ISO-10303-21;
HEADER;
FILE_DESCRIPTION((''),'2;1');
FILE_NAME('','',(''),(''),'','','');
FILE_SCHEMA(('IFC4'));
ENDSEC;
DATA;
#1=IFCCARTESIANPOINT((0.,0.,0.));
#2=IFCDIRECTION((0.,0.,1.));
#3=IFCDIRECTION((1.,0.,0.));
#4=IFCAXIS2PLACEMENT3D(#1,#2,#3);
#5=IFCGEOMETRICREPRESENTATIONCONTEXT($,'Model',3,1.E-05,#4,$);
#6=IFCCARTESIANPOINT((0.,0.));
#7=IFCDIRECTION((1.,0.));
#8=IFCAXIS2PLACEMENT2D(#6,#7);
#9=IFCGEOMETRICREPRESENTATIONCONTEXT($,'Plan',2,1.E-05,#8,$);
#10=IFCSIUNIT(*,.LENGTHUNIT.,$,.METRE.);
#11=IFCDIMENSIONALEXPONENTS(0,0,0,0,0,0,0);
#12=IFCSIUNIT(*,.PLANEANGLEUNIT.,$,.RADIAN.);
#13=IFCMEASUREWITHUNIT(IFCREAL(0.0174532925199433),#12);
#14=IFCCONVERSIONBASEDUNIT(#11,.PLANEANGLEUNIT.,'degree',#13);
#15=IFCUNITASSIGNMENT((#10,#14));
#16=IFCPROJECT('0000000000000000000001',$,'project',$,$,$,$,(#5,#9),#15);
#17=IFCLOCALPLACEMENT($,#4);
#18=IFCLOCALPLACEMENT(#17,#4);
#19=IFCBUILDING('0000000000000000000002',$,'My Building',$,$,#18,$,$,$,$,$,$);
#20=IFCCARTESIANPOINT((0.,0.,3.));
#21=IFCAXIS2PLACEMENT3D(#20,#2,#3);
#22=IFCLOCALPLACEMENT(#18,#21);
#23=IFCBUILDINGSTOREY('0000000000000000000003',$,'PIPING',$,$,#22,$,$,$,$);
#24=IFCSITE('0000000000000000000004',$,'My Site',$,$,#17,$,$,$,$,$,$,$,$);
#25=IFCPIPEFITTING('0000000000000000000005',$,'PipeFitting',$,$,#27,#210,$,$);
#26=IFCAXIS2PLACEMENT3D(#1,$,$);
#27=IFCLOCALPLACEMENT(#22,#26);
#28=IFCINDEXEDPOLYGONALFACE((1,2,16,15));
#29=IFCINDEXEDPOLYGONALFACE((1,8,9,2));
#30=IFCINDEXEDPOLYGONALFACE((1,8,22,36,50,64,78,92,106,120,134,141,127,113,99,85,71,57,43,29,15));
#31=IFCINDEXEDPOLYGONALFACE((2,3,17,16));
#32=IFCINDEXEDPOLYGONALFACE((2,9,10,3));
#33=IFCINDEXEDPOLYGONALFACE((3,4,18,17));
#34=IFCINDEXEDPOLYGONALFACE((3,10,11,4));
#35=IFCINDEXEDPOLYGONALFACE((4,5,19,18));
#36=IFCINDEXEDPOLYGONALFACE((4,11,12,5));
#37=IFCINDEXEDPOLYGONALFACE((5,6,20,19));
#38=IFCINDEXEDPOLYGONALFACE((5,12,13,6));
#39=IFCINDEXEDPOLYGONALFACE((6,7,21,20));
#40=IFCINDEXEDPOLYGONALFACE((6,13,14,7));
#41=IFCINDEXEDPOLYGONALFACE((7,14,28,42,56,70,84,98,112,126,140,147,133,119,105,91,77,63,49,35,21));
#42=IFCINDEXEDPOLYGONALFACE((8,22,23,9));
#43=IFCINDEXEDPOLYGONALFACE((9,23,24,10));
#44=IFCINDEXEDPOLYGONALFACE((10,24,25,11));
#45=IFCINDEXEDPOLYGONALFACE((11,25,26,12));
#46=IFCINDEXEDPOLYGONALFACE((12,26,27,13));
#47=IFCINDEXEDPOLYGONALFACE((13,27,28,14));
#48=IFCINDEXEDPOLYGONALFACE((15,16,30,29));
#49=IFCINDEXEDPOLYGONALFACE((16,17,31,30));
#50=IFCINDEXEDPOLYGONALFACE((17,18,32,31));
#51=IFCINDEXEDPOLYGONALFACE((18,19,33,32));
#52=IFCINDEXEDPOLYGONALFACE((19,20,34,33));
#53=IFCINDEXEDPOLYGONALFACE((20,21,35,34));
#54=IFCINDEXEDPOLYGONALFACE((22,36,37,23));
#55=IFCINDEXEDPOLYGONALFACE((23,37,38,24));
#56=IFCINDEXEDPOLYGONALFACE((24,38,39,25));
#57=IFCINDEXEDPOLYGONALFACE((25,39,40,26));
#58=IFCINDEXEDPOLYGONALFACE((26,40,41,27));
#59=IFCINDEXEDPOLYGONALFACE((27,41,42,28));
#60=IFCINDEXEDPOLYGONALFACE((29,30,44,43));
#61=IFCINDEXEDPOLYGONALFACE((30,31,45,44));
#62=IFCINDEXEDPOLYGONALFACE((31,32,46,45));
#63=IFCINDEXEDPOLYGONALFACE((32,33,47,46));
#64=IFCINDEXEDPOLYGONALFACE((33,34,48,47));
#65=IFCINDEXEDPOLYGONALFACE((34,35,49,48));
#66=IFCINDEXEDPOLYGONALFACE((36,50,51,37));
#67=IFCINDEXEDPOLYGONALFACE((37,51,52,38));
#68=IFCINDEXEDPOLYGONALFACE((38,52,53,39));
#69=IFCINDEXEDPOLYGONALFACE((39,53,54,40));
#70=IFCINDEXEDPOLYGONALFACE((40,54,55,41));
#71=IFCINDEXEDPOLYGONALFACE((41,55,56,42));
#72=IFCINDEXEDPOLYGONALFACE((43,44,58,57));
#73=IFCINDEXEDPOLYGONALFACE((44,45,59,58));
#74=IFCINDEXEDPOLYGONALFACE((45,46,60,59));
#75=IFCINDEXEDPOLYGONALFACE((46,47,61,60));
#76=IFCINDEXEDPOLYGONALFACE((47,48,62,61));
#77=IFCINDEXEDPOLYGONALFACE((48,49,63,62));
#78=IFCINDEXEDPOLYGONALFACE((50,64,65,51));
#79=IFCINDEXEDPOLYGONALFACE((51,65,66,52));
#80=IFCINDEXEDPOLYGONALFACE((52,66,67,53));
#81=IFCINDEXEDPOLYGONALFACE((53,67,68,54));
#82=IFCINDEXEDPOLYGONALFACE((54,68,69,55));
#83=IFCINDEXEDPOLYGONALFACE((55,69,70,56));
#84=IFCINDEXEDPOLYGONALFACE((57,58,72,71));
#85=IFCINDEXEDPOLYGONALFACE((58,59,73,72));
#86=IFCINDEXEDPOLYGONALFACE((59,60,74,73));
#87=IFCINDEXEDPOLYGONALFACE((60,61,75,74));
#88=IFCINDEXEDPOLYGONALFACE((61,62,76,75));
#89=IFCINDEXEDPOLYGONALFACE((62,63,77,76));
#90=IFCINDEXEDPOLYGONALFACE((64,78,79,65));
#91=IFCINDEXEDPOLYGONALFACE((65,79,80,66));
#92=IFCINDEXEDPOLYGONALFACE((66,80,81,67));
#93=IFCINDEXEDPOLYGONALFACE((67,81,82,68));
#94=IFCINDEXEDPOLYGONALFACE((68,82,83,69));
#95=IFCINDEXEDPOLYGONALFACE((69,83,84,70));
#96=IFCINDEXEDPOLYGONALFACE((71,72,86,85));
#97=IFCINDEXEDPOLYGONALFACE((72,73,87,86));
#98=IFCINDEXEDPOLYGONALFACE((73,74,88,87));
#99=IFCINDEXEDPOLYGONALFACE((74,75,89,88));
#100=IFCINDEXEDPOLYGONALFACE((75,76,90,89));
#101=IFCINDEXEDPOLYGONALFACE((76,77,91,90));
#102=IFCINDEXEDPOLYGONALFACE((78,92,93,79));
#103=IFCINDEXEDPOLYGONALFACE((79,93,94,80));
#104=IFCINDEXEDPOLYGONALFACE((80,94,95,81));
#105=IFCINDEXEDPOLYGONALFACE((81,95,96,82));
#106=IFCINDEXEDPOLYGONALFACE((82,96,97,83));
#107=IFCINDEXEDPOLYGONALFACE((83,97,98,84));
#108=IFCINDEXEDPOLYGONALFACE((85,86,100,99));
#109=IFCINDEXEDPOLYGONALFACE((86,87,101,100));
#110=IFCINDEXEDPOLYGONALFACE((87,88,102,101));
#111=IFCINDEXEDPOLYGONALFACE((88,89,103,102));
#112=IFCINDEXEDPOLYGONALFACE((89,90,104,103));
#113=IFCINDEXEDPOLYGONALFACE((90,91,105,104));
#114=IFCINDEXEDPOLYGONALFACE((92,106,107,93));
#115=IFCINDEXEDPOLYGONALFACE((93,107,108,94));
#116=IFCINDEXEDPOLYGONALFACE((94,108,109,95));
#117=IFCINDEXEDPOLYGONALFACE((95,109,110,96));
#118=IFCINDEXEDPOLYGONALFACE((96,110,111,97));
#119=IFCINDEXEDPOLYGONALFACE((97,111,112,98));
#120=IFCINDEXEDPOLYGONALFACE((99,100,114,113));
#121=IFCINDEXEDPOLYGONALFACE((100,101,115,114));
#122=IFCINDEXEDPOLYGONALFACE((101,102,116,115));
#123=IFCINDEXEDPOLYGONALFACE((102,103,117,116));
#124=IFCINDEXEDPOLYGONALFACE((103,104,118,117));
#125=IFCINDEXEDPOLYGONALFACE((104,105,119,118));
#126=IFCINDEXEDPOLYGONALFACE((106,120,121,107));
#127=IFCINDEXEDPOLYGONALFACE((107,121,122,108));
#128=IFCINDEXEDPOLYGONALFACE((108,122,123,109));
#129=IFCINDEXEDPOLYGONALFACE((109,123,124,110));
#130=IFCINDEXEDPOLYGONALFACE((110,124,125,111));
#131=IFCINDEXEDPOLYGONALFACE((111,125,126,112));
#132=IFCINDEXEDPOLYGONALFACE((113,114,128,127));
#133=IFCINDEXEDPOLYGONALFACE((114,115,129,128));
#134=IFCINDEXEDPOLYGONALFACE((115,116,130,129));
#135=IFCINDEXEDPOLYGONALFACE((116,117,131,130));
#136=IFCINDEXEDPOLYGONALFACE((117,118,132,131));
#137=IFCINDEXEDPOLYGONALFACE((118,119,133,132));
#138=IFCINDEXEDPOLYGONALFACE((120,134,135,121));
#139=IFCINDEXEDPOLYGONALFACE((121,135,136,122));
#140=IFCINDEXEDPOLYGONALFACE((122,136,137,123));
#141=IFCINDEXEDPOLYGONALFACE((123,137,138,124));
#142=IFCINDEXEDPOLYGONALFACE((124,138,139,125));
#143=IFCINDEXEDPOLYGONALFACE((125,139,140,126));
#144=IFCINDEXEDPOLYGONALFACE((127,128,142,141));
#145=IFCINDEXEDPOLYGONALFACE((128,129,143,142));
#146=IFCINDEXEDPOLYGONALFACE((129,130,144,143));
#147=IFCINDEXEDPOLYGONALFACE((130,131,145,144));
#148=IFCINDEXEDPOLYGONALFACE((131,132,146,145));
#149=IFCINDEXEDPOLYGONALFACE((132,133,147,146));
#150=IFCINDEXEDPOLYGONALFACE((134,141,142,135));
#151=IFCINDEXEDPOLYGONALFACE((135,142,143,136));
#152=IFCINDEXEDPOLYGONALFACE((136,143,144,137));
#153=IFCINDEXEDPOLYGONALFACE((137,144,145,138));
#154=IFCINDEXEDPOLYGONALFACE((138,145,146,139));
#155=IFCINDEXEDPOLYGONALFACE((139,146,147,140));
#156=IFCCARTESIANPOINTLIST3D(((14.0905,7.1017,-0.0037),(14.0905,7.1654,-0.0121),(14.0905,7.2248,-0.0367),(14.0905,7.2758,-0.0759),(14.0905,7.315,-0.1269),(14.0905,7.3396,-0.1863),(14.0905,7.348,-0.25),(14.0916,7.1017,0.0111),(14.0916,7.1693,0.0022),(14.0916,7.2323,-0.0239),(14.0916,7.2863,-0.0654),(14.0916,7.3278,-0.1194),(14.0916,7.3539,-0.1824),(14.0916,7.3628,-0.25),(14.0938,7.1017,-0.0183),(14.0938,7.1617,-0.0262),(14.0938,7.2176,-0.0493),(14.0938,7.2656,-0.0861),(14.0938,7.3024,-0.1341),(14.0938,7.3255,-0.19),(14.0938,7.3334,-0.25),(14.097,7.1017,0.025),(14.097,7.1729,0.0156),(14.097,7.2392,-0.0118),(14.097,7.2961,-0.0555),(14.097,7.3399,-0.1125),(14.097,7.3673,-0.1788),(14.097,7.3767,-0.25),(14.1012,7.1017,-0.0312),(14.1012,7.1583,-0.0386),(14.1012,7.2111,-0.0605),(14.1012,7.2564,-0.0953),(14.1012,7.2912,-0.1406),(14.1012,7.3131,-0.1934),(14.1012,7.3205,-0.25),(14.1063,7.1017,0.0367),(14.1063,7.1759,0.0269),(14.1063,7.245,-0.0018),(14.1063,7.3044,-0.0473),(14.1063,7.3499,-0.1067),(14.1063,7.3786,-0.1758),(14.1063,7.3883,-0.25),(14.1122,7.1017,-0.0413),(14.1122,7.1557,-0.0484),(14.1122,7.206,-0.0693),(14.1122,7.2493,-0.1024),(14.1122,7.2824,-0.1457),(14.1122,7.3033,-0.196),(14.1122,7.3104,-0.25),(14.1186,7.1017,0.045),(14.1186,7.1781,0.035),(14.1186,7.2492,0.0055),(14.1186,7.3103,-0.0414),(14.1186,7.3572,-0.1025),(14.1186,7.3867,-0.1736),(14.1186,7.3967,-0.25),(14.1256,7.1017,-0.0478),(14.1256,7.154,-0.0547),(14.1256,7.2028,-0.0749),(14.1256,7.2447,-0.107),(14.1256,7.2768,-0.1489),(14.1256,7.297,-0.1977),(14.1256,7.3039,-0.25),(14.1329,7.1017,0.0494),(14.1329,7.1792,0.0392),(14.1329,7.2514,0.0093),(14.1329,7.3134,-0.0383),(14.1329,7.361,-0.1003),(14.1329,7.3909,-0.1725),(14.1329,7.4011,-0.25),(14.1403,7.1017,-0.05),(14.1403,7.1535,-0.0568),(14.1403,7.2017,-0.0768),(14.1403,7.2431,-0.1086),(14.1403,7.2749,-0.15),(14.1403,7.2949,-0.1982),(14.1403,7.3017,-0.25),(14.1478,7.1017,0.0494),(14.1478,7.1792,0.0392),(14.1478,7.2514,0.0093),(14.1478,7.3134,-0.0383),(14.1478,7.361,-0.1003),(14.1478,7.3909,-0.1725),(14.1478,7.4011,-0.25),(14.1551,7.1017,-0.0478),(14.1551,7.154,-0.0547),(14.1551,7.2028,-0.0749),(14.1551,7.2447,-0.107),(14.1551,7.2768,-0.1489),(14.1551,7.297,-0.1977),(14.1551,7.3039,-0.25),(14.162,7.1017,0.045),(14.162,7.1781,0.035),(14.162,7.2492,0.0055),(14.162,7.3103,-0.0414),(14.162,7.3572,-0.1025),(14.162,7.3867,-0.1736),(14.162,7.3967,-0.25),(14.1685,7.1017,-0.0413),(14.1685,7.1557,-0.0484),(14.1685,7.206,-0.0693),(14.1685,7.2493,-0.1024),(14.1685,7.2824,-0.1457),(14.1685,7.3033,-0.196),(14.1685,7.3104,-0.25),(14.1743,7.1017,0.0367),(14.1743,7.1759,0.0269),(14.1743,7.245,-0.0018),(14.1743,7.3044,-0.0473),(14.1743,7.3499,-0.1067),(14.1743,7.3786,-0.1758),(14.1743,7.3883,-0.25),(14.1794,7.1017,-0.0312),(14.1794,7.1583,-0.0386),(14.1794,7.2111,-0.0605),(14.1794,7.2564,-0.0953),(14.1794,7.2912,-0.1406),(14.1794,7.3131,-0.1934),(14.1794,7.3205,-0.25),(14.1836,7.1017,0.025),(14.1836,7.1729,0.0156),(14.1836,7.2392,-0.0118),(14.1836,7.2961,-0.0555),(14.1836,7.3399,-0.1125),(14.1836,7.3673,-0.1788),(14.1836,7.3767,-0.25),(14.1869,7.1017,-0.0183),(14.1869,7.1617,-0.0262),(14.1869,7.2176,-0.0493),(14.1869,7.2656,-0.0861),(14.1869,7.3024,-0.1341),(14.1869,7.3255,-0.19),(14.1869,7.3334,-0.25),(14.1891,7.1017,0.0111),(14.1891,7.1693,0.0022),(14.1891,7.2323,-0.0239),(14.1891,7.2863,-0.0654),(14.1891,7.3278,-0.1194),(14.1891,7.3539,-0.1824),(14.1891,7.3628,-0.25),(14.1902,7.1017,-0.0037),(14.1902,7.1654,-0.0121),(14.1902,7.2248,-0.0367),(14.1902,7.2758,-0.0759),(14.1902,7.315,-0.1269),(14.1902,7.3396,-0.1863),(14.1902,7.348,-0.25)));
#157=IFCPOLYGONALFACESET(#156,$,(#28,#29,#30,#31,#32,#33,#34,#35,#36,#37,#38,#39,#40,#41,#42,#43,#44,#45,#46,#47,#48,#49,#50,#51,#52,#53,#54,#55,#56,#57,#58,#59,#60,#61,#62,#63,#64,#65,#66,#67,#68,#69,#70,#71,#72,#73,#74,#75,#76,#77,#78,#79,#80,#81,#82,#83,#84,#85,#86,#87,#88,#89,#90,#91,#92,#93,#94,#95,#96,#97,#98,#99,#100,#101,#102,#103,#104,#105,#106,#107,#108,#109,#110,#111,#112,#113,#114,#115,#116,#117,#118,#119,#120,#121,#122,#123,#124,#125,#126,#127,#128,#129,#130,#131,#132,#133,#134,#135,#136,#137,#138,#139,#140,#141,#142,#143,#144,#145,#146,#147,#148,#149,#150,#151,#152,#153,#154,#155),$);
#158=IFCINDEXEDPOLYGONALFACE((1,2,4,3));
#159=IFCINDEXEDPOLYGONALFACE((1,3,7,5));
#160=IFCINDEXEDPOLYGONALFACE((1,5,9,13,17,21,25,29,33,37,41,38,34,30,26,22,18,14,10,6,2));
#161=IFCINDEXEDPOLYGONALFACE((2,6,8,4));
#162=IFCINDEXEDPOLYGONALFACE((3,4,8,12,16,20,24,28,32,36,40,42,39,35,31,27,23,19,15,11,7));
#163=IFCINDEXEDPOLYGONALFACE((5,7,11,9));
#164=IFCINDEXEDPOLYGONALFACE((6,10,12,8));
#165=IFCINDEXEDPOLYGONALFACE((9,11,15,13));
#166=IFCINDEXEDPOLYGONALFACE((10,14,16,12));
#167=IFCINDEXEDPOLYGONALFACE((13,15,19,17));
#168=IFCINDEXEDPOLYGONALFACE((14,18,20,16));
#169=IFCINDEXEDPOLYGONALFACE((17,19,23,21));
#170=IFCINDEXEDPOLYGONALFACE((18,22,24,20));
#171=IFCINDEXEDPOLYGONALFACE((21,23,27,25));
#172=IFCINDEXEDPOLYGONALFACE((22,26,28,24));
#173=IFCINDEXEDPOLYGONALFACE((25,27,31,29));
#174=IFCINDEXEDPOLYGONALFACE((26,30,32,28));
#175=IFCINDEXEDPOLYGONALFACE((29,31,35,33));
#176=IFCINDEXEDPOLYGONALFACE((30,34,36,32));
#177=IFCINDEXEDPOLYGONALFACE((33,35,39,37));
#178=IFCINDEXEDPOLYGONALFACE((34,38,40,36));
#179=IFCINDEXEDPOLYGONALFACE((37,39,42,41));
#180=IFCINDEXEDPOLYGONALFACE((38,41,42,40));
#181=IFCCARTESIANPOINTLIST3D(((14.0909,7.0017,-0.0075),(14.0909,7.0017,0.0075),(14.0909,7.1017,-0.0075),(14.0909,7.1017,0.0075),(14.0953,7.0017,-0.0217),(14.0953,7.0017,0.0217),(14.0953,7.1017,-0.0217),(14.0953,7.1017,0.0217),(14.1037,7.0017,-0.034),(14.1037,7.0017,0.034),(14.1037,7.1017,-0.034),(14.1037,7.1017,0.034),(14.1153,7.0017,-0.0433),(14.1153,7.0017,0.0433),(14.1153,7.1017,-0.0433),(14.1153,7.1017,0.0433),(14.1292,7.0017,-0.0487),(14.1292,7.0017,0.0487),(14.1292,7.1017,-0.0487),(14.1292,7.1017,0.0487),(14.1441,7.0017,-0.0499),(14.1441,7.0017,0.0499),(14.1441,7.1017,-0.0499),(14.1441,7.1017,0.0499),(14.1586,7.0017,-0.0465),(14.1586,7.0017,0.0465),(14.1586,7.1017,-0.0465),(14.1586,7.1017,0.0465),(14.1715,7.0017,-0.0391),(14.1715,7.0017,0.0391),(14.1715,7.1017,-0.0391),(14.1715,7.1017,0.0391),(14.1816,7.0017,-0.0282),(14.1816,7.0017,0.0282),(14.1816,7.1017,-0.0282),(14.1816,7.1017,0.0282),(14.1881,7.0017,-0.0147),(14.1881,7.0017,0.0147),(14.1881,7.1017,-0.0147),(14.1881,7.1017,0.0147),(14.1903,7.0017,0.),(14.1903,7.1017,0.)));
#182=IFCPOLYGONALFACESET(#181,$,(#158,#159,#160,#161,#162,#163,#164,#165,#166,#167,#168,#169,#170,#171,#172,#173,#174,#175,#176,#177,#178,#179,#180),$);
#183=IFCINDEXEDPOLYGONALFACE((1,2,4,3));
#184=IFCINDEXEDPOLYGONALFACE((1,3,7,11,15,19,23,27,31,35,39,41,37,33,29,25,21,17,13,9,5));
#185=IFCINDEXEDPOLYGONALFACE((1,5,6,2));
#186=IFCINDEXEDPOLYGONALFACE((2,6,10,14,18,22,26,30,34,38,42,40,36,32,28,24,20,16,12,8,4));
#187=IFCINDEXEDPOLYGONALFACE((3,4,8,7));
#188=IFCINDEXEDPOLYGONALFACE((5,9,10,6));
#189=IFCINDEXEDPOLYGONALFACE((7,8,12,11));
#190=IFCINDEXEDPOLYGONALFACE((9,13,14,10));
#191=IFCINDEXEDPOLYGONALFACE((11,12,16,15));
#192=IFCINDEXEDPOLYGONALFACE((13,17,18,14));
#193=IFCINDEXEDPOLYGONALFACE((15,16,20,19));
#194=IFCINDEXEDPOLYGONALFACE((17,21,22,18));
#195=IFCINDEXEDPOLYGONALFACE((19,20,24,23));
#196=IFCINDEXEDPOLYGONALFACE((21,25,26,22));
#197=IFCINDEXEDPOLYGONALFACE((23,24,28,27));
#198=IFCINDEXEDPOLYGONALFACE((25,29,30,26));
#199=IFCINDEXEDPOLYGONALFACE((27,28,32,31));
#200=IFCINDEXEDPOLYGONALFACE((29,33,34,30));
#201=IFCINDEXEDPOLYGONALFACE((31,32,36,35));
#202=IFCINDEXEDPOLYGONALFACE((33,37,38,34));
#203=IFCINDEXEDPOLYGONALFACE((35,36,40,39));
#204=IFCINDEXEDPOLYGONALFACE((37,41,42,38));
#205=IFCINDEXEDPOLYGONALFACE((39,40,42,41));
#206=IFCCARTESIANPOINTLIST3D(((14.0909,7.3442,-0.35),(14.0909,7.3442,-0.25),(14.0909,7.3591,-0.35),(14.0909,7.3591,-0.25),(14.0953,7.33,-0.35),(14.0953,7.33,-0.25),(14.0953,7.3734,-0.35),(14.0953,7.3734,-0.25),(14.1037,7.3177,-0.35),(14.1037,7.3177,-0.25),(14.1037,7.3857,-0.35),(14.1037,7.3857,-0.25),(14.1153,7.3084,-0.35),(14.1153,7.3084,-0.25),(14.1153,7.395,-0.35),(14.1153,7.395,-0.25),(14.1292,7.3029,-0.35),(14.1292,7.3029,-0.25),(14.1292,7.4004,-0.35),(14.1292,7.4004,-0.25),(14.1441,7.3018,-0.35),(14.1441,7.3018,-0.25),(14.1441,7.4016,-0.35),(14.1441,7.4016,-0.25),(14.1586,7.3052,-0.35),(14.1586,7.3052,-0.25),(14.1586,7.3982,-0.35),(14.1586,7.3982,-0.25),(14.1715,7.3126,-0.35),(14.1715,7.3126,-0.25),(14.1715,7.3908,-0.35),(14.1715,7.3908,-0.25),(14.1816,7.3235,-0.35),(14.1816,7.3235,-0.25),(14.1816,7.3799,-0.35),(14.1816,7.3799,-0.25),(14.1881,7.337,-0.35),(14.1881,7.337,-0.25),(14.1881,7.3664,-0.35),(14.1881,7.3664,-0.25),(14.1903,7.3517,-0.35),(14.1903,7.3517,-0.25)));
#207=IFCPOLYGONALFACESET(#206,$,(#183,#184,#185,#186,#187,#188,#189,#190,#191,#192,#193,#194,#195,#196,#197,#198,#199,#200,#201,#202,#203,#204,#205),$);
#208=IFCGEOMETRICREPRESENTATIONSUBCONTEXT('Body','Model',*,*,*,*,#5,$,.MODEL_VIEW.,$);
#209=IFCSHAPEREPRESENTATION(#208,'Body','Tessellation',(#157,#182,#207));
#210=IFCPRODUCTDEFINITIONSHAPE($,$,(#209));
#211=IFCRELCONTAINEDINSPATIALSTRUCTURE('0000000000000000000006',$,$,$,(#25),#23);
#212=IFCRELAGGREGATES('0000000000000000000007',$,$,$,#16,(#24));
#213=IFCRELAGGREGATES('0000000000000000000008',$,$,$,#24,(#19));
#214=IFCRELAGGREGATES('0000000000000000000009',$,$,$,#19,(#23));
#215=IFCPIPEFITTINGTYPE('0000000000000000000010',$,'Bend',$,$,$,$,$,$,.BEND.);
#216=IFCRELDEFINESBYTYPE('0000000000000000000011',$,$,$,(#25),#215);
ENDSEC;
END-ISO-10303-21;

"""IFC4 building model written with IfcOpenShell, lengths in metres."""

from ifc_helpers import new_model, entity, si_unit, converted_unit, frame, origin_with_axes, origin_2d_with_axis, place, context, subcontext, project, spatial, circle, extrude, source, transform, mapped, type_object, type_shapes, element, save


model = new_model("IFC4")

# Units and contexts
model_context = context("Model", 3, precision=1e-05, world=origin_with_axes())
plan_context = context("Plan", 2, precision=1e-05, world=origin_2d_with_axis())
body_context = subcontext(model_context, "Body", "Model", "MODEL_VIEW")
ifc_project = project(units=[si_unit("LENGTHUNIT", "METRE"), converted_unit("PLANEANGLEUNIT", "degree", entity("IfcReal", 0.0174532925199433), si_unit("PLANEANGLEUNIT", "RADIAN"), dimensions=[0, 0, 0, 0, 0, 0, 0])], contexts=[model_context, plan_context])

# Site, building, storey
site_placement = place(None, origin_with_axes())
site = spatial("IfcSite", under=ifc_project, at=site_placement, Name="My Site")
building_placement = place(site_placement, origin_with_axes())
building = spatial("IfcBuilding", under=site, at=building_placement, Name="My Building")
storey_placement = place(building_placement, frame((0.0, 0.0, 3.0), z_axis=(0.0, 0.0, 1.0), x_axis=(1.0, 0.0, 0.0)))
storey = spatial("IfcBuildingStorey", under=building, at=storey_placement, Name="PIPING")

# Pipe fitting
pipe_fitting_type = type_object("IfcPipeFittingType", Name="Bend", PredefinedType="BEND")
shared_shape = source(origin_with_axes(), body_context, "Body", "SolidModel", [
    entity("IfcSweptDiskSolid", entity("IfcIndexedPolyCurve", entity("IfcCartesianPointList3D", [[0.0, 0.0, -0.1], [0.0, -0.0732, -0.2768], [0.0, -0.25, -0.35]]), [entity("IfcArcIndex", [1, 2, 3])]), 0.05),
    extrude(circle(Radius=0.05), origin_with_axes(), (0.0, 0.0, -1.0), 0.1),
    extrude(circle(Radius=0.05), frame((0.0, -0.25, -0.35), z_axis=(0.0, -1.0, 0.0), x_axis=(1.0, 0.0, 0.0)), (0.0, 0.0, 1.0), 0.1),
])
type_shapes(pipe_fitting_type, [shared_shape])
for number, where, z_axis, x_axis, name in (
    (1, (14.1403, 7.0017, 0.0), (0.0, -1.0, 0.0), (1.0, 0.0, 0.0), "PipeFitting"),
):
    element("IfcPipeFitting", number, at=place(storey_placement, frame(where, z_axis=z_axis, x_axis=x_axis)), inside=storey, type_object=pipe_fitting_type, Name=name, context=body_context, shape_type="MappedRepresentation", body=[
        mapped(shared_shape, transform((0.0, 0.0, 0.0), x_axis=(1.0, 0.0, 0.0), y_axis=(0.0, 1.0, 0.0), z_axis=(0.0, 0.0, 1.0), scale=1.0)),
    ])

save(model, "model.ifc")
